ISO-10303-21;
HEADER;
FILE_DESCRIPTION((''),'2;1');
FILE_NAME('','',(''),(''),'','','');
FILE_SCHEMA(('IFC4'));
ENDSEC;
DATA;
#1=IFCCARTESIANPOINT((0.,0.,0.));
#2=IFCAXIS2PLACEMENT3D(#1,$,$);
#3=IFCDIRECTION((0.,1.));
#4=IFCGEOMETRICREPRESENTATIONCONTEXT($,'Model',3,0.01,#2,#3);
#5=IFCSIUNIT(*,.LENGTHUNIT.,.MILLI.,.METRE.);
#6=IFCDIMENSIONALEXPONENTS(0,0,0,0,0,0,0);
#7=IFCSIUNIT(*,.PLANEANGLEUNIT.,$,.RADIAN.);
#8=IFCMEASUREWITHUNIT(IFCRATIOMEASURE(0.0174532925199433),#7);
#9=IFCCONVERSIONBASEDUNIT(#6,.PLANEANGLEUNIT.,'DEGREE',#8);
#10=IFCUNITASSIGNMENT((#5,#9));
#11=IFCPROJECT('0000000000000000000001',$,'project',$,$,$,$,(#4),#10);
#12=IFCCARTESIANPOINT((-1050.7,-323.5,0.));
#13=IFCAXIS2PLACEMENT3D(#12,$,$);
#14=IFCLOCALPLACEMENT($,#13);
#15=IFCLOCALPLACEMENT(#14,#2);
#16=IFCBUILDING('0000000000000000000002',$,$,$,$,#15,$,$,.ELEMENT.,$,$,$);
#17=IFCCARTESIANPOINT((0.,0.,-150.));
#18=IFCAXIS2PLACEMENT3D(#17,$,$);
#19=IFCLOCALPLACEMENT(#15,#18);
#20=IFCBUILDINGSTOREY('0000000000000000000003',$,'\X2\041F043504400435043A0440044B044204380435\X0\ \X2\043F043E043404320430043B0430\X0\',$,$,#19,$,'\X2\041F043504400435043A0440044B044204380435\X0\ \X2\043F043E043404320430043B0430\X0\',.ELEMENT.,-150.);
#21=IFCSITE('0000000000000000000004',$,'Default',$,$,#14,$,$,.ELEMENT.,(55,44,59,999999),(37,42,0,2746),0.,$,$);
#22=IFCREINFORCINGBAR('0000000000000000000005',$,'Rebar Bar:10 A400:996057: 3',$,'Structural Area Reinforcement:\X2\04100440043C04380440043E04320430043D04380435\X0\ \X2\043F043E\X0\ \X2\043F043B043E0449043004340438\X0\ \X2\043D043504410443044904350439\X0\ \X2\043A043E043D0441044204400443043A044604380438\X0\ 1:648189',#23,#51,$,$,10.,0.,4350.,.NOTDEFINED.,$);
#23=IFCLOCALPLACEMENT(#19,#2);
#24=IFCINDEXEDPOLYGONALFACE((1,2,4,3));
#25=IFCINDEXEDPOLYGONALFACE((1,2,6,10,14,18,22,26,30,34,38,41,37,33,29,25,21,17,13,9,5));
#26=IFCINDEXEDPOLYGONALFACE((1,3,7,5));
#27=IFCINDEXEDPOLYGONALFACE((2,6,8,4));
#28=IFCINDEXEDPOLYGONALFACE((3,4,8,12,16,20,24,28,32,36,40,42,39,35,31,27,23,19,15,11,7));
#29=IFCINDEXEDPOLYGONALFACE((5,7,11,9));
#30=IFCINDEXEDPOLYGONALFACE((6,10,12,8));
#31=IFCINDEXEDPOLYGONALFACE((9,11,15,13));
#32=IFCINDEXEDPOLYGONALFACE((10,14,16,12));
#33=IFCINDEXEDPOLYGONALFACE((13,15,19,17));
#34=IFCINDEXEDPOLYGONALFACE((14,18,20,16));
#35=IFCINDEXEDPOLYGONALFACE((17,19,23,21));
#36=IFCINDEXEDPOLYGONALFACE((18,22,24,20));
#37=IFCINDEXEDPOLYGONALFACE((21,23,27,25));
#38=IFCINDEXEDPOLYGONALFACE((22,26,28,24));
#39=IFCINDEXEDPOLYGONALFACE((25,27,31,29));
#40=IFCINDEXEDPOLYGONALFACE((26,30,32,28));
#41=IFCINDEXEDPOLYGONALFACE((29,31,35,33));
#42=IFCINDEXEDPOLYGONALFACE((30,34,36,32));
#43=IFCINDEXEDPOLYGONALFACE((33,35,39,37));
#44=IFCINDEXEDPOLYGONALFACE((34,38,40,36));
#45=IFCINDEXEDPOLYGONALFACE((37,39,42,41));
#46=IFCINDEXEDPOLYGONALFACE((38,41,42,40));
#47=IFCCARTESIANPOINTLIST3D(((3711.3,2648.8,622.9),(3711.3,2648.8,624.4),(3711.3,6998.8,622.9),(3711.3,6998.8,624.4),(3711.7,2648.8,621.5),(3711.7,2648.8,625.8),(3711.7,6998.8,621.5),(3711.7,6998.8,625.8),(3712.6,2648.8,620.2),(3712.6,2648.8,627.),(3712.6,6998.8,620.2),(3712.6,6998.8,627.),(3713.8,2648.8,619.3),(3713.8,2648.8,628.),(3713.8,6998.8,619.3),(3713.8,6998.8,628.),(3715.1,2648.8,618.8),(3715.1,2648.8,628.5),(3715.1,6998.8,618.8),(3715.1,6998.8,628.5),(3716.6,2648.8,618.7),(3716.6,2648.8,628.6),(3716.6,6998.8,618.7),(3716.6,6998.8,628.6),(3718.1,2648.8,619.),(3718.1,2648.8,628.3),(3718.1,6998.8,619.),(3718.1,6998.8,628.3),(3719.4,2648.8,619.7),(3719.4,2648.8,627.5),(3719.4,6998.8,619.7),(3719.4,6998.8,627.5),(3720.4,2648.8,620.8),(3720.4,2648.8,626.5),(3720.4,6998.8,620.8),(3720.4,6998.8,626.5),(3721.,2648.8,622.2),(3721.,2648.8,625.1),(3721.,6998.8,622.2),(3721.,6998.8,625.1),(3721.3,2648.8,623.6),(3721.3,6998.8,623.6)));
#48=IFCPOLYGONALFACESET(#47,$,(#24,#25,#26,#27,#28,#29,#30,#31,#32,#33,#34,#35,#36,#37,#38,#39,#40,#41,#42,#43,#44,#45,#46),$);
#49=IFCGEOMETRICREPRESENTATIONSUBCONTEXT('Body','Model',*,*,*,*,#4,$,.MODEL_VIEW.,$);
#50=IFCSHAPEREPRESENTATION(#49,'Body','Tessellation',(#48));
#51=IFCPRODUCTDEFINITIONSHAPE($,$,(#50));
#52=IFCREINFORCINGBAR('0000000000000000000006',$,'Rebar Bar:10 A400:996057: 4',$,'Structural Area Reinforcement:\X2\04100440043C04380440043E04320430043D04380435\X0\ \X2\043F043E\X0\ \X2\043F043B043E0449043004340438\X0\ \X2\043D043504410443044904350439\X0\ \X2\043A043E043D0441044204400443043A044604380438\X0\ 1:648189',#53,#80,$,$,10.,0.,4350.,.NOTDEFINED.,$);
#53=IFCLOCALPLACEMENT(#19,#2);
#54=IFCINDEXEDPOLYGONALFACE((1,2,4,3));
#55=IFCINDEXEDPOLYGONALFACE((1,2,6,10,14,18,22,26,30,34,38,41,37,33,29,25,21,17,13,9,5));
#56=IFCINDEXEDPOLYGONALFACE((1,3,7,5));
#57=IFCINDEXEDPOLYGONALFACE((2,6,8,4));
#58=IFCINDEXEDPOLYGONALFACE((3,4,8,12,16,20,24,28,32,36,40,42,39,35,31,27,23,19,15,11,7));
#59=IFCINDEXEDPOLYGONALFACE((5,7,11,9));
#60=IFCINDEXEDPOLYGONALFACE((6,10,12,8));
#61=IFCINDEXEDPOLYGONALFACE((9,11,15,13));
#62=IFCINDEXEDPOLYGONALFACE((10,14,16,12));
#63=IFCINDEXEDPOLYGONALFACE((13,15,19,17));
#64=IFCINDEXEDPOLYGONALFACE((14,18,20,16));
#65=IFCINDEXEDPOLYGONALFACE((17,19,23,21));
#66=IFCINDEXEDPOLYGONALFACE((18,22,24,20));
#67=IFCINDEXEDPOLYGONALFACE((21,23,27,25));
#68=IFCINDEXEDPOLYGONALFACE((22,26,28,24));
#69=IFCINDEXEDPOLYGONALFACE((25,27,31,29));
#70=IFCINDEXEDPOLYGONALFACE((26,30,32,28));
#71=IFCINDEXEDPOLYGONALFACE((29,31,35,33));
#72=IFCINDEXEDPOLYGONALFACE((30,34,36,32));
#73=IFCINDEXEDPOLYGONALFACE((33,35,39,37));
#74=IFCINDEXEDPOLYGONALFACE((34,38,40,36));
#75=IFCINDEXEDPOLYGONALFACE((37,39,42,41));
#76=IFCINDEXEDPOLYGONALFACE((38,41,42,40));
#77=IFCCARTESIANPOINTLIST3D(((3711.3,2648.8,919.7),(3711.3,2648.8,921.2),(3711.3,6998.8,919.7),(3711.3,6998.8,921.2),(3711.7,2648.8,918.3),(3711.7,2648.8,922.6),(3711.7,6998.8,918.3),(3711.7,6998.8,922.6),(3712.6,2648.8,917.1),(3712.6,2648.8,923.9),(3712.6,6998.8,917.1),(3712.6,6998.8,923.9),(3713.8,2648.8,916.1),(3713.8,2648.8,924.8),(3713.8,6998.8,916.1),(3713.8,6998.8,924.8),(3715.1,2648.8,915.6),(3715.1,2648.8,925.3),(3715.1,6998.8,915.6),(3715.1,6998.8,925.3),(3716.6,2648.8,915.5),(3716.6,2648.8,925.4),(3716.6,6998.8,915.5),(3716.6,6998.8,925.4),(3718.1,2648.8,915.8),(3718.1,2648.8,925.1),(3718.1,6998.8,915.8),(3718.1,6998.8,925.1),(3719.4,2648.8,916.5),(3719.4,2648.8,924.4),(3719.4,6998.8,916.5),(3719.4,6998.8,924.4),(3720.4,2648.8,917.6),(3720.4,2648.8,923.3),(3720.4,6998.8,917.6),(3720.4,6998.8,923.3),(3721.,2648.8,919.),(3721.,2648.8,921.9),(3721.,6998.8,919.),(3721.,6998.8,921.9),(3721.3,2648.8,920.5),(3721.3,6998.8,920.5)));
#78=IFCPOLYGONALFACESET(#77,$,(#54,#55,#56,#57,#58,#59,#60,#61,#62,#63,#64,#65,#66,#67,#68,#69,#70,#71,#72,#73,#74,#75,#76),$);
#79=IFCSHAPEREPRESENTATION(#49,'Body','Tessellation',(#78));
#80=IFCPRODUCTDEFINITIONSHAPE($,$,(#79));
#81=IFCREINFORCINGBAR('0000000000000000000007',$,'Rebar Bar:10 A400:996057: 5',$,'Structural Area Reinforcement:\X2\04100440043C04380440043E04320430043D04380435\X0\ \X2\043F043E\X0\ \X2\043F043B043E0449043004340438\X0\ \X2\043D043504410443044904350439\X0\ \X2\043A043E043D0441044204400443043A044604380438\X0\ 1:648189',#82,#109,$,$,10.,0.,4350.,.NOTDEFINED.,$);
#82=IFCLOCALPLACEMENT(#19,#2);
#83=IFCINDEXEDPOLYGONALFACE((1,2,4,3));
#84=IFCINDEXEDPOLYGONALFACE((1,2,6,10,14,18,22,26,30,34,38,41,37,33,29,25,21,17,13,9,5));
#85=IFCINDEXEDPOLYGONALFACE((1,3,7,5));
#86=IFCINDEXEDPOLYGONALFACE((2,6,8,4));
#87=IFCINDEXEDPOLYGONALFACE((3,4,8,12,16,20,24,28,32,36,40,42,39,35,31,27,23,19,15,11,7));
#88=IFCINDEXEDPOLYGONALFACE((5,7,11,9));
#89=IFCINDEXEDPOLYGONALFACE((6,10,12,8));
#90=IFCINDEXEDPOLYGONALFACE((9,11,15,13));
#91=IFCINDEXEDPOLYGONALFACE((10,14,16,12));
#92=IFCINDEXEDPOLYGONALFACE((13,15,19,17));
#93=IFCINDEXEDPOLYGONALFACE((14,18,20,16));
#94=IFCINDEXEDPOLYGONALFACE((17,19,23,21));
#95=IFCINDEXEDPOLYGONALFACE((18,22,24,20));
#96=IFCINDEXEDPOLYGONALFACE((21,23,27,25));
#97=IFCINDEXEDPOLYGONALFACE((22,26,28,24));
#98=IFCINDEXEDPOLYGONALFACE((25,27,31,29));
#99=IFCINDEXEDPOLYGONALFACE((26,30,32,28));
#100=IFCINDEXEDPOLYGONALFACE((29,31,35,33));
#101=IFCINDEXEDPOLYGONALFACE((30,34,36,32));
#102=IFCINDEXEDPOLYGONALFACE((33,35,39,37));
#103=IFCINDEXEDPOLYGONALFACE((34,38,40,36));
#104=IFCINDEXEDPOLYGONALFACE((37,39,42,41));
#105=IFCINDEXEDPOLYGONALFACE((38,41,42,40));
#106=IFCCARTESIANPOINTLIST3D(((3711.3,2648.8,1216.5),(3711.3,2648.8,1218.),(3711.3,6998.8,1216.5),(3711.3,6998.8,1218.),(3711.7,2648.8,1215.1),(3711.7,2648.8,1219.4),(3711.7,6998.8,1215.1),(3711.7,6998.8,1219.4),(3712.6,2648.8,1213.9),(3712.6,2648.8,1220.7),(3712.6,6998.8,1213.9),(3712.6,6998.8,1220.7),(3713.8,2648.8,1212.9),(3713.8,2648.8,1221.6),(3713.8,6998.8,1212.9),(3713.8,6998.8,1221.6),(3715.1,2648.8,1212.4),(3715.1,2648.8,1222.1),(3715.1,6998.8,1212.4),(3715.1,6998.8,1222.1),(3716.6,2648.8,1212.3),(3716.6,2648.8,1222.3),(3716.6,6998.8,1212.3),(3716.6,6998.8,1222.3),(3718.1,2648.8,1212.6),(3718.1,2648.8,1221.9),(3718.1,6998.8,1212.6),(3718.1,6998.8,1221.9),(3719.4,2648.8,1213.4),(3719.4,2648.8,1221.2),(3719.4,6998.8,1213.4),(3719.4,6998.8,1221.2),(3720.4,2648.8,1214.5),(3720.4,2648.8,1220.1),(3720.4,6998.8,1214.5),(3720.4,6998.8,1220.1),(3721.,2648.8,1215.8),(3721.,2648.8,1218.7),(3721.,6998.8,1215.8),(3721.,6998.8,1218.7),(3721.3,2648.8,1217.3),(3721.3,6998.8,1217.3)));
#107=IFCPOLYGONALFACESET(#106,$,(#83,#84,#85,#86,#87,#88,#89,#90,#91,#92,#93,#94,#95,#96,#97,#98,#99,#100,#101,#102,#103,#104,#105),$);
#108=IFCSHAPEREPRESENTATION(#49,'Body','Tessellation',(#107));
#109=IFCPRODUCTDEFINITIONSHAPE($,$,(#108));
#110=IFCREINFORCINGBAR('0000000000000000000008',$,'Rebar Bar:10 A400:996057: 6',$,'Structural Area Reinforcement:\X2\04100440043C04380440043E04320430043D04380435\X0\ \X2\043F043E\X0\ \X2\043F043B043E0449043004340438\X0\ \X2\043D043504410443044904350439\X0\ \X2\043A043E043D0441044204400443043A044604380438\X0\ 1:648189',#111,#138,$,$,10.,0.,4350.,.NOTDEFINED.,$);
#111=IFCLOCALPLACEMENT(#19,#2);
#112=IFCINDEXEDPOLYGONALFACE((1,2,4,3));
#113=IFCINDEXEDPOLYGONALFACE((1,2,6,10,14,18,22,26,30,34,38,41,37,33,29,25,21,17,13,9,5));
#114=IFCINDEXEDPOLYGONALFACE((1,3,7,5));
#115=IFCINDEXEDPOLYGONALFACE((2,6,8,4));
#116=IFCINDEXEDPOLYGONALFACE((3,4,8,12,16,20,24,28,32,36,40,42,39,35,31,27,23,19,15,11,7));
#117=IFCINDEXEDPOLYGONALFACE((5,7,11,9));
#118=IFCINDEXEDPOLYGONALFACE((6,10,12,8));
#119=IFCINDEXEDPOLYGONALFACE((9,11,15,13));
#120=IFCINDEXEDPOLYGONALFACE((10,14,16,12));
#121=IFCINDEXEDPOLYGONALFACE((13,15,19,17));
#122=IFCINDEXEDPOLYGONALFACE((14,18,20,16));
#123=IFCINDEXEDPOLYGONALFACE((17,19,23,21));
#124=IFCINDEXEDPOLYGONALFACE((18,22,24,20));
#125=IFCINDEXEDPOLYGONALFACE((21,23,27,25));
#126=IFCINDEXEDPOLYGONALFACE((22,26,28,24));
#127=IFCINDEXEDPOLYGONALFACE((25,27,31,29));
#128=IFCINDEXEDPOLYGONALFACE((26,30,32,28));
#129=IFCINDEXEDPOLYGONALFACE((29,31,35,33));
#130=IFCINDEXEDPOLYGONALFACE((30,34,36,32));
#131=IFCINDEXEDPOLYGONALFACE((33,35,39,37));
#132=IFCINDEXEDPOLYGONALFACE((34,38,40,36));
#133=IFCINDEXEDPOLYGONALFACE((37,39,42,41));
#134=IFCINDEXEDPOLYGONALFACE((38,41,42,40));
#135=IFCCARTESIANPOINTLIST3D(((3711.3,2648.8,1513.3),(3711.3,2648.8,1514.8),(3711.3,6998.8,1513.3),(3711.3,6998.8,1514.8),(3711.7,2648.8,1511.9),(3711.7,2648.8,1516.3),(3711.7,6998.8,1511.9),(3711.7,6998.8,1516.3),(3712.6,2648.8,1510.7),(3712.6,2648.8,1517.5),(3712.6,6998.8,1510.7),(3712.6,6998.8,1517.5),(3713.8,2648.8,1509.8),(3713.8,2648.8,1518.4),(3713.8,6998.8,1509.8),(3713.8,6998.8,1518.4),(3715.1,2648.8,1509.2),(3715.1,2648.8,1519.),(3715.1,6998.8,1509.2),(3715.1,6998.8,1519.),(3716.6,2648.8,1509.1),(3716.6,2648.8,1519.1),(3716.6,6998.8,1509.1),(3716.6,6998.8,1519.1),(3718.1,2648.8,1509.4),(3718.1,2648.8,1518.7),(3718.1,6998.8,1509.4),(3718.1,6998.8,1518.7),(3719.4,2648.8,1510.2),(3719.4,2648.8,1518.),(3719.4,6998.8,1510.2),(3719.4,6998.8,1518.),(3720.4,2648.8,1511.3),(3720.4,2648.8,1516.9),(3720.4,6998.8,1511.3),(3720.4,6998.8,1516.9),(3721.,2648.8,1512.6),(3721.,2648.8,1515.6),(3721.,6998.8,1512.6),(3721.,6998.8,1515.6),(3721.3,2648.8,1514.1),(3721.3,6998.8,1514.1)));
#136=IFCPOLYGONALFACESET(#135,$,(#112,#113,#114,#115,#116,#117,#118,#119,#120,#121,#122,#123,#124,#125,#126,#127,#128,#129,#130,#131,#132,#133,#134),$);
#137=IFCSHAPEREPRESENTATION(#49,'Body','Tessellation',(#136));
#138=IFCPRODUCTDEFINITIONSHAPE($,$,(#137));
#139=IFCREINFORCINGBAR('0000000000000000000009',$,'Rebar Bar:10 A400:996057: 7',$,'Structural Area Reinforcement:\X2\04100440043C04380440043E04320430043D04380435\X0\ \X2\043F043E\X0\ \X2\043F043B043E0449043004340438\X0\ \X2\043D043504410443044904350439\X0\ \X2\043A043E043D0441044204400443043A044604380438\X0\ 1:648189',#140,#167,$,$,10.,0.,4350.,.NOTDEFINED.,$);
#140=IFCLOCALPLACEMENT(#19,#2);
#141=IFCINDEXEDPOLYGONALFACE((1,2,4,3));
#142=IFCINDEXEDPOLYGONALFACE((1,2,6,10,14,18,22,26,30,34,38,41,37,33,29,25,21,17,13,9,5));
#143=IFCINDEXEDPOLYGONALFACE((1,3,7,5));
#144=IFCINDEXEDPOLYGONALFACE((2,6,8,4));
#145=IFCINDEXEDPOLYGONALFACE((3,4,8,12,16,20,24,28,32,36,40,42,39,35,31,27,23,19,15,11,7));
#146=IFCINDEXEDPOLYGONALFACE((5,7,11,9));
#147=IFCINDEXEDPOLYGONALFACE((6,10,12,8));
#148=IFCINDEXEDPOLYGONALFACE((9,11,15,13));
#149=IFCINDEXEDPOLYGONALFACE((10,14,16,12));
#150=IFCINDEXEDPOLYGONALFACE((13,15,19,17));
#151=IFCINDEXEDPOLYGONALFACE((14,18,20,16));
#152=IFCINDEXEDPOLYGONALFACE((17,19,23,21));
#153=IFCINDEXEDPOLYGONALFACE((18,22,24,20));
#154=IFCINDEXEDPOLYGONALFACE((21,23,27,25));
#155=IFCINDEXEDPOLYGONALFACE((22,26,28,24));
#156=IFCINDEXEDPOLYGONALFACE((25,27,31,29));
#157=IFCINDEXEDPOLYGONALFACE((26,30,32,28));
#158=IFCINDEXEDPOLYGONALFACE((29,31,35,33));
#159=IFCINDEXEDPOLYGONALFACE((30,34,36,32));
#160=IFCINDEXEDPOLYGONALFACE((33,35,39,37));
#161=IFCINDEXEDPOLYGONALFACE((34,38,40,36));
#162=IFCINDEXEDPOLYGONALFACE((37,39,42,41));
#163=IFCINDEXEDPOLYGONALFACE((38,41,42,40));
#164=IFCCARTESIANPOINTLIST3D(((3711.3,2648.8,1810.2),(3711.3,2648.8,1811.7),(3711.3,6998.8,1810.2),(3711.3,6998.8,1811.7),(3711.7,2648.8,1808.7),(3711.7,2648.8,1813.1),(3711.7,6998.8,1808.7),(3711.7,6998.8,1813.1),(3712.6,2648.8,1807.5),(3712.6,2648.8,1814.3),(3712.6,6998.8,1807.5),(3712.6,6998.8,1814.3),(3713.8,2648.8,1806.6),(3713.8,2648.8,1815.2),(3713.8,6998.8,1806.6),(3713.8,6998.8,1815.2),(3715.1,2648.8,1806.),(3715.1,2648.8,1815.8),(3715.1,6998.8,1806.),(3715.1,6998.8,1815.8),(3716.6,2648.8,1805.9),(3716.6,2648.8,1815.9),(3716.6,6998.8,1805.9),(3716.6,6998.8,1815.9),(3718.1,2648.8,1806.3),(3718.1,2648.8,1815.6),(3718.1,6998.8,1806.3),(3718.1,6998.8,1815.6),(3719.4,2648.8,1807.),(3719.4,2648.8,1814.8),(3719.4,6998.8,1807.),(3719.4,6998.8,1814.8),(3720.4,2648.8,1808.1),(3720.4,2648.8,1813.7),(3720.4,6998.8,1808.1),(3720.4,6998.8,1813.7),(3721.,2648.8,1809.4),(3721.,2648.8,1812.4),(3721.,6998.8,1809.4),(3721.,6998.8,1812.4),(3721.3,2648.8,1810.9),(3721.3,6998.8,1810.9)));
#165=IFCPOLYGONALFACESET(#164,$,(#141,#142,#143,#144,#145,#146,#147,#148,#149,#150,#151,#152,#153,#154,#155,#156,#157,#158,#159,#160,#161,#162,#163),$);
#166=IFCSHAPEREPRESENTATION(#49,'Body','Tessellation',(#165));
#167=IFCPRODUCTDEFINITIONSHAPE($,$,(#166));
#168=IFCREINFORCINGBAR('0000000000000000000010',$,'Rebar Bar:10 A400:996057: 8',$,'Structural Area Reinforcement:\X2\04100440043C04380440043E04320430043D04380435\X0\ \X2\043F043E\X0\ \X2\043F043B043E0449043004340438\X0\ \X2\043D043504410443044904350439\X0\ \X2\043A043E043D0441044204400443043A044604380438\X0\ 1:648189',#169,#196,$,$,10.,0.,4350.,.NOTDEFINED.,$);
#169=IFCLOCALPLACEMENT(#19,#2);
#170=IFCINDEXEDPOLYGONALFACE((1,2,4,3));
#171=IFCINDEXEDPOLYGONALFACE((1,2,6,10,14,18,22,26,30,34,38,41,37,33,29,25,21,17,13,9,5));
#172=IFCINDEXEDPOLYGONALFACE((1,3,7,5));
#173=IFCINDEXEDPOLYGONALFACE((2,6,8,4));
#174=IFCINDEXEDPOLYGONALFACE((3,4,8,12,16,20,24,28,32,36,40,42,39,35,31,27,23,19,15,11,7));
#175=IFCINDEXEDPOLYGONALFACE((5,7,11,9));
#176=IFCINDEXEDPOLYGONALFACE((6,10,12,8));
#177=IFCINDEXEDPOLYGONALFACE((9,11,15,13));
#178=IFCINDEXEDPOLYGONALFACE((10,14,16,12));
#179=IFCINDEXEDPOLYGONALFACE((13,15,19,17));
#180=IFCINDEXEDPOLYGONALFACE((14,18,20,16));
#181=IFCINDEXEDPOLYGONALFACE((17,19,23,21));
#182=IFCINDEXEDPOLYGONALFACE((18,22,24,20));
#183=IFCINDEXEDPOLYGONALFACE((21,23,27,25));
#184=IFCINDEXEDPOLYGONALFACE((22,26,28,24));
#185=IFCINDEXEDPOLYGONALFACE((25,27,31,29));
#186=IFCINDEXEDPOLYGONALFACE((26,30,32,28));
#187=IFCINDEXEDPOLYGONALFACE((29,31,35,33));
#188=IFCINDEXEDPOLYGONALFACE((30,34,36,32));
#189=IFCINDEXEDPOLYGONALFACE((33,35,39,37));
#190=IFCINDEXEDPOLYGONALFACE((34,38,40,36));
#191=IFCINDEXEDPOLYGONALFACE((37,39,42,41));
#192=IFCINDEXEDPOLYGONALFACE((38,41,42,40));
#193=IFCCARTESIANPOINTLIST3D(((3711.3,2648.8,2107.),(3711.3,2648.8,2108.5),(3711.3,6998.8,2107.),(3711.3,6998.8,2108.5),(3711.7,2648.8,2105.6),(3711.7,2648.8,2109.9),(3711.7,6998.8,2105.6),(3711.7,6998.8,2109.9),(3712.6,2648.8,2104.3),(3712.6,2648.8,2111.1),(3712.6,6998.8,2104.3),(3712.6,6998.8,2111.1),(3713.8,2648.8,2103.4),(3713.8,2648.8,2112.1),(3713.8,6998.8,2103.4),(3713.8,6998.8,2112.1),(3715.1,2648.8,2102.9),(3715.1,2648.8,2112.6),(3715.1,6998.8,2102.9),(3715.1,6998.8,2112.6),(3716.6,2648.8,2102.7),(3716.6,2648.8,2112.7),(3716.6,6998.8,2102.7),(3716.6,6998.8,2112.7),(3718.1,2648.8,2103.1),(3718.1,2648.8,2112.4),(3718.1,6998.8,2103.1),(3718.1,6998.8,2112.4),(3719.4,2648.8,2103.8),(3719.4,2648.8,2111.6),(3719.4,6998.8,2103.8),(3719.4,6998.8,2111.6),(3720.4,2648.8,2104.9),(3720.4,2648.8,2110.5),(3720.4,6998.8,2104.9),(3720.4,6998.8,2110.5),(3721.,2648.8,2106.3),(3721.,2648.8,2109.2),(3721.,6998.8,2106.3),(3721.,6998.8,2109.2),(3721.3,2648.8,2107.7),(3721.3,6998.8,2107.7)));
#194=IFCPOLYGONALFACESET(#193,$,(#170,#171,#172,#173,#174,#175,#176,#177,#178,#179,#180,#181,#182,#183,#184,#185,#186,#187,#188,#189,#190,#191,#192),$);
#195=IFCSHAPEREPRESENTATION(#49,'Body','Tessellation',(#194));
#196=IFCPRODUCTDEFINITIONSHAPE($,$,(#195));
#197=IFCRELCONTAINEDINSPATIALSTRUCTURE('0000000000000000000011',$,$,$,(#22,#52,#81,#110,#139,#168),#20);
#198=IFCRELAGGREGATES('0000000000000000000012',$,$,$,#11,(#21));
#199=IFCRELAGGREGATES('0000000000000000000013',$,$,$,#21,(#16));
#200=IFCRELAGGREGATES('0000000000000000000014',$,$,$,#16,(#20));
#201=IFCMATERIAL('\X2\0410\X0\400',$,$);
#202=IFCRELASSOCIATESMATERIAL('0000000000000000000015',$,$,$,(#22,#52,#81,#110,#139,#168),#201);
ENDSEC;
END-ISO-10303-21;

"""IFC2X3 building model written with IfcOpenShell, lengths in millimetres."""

from ifc_helpers import new_model, entity, si_unit, converted_unit, direction, frame, origin, place, context, subcontext, project, spatial, material, element, save


model = new_model("IFC2X3")

# Units and contexts
model_context = context("Model", 3, precision=0.01, world=origin(), true_north=direction((0.0, 1.0)))
body_context = subcontext(model_context, "Body", "Model", "MODEL_VIEW")
ifc_project = project(units=[si_unit("LENGTHUNIT", "METRE", prefix="MILLI"), converted_unit("PLANEANGLEUNIT", "DEGREE", entity("IfcRatioMeasure", 0.0174532925199433), si_unit("PLANEANGLEUNIT", "RADIAN"), dimensions=[0, 0, 0, 0, 0, 0, 0])], contexts=[model_context])

# Site, building, storey
site_placement = place(None, frame((-1050.7, -323.5, 0.0)))
site = spatial("IfcSite", under=ifc_project, at=site_placement, Name="Default", CompositionType="ELEMENT", RefLatitude=(55, 44, 59, 999999), RefLongitude=(37, 42, 0, 2746), RefElevation=0.0)
building_placement = place(site_placement, origin())
building = spatial("IfcBuilding", under=site, at=building_placement, CompositionType="ELEMENT")
storey_placement = place(building_placement, frame((0.0, 0.0, -150.0)))
storey = spatial("IfcBuildingStorey", under=building, at=storey_placement, Name="Перекрытие подвала", LongName="Перекрытие подвала", CompositionType="ELEMENT", Elevation=-150.0)

# Reinforcing bars
ifc_material = material(Name="А400")
reinforcing_bar_1_placement = place(storey_placement, origin())
element("IfcReinforcingBar", 1, at=reinforcing_bar_1_placement, inside=storey, material=ifc_material, Name="Rebar Bar:10 A400:996057: 3", ObjectType="Structural Area Reinforcement:Армирование по площади несущей конструкции 1:648189", BarLength=4350.0, BarRole="NOTDEFINED", CrossSectionArea=0.0, NominalDiameter=10.0, context=body_context, shape_type="AdvancedSweptSolid", body=[
    entity("IfcSweptDiskSolid", entity("IfcCompositeCurve", [entity("IfcCompositeCurveSegment", "CONTINUOUS", True, entity("IfcPolyline", [entity("IfcCartesianPoint", [3716.3, 2648.8, 623.6]), entity("IfcCartesianPoint", [3716.3, 6998.8, 623.6])]))], False), 5.0, None, 0.0, 1.0),
])
reinforcing_bar_2_placement = place(storey_placement, origin())
element("IfcReinforcingBar", 2, at=reinforcing_bar_2_placement, inside=storey, material=ifc_material, Name="Rebar Bar:10 A400:996057: 4", ObjectType="Structural Area Reinforcement:Армирование по площади несущей конструкции 1:648189", BarLength=4350.0, BarRole="NOTDEFINED", CrossSectionArea=0.0, NominalDiameter=10.0, context=body_context, shape_type="AdvancedSweptSolid", body=[
    entity("IfcSweptDiskSolid", entity("IfcCompositeCurve", [entity("IfcCompositeCurveSegment", "CONTINUOUS", True, entity("IfcPolyline", [entity("IfcCartesianPoint", [3716.3, 2648.8, 920.5]), entity("IfcCartesianPoint", [3716.3, 6998.8, 920.5])]))], False), 5.0, None, 0.0, 1.0),
])
reinforcing_bar_3_placement = place(storey_placement, origin())
element("IfcReinforcingBar", 3, at=reinforcing_bar_3_placement, inside=storey, material=ifc_material, Name="Rebar Bar:10 A400:996057: 5", ObjectType="Structural Area Reinforcement:Армирование по площади несущей конструкции 1:648189", BarLength=4350.0, BarRole="NOTDEFINED", CrossSectionArea=0.0, NominalDiameter=10.0, context=body_context, shape_type="AdvancedSweptSolid", body=[
    entity("IfcSweptDiskSolid", entity("IfcCompositeCurve", [entity("IfcCompositeCurveSegment", "CONTINUOUS", True, entity("IfcPolyline", [entity("IfcCartesianPoint", [3716.3, 2648.8, 1217.3]), entity("IfcCartesianPoint", [3716.3, 6998.8, 1217.3])]))], False), 5.0, None, 0.0, 1.0),
])
reinforcing_bar_4_placement = place(storey_placement, origin())
element("IfcReinforcingBar", 4, at=reinforcing_bar_4_placement, inside=storey, material=ifc_material, Name="Rebar Bar:10 A400:996057: 6", ObjectType="Structural Area Reinforcement:Армирование по площади несущей конструкции 1:648189", BarLength=4350.0, BarRole="NOTDEFINED", CrossSectionArea=0.0, NominalDiameter=10.0, context=body_context, shape_type="AdvancedSweptSolid", body=[
    entity("IfcSweptDiskSolid", entity("IfcCompositeCurve", [entity("IfcCompositeCurveSegment", "CONTINUOUS", True, entity("IfcPolyline", [entity("IfcCartesianPoint", [3716.3, 2648.8, 1514.1]), entity("IfcCartesianPoint", [3716.3, 6998.8, 1514.1])]))], False), 5.0, None, 0.0, 1.0),
])
reinforcing_bar_5_placement = place(storey_placement, origin())
element("IfcReinforcingBar", 5, at=reinforcing_bar_5_placement, inside=storey, material=ifc_material, Name="Rebar Bar:10 A400:996057: 7", ObjectType="Structural Area Reinforcement:Армирование по площади несущей конструкции 1:648189", BarLength=4350.0, BarRole="NOTDEFINED", CrossSectionArea=0.0, NominalDiameter=10.0, context=body_context, shape_type="AdvancedSweptSolid", body=[
    entity("IfcSweptDiskSolid", entity("IfcCompositeCurve", [entity("IfcCompositeCurveSegment", "CONTINUOUS", True, entity("IfcPolyline", [entity("IfcCartesianPoint", [3716.3, 2648.8, 1810.9]), entity("IfcCartesianPoint", [3716.3, 6998.8, 1810.9])]))], False), 5.0, None, 0.0, 1.0),
])
reinforcing_bar_6_placement = place(storey_placement, origin())
element("IfcReinforcingBar", 6, at=reinforcing_bar_6_placement, inside=storey, material=ifc_material, Name="Rebar Bar:10 A400:996057: 8", ObjectType="Structural Area Reinforcement:Армирование по площади несущей конструкции 1:648189", BarLength=4350.0, BarRole="NOTDEFINED", CrossSectionArea=0.0, NominalDiameter=10.0, context=body_context, shape_type="AdvancedSweptSolid", body=[
    entity("IfcSweptDiskSolid", entity("IfcCompositeCurve", [entity("IfcCompositeCurveSegment", "CONTINUOUS", True, entity("IfcPolyline", [entity("IfcCartesianPoint", [3716.3, 2648.8, 2107.7]), entity("IfcCartesianPoint", [3716.3, 6998.8, 2107.7])]))], False), 5.0, None, 0.0, 1.0),
])

save(model, "model.ifc")
